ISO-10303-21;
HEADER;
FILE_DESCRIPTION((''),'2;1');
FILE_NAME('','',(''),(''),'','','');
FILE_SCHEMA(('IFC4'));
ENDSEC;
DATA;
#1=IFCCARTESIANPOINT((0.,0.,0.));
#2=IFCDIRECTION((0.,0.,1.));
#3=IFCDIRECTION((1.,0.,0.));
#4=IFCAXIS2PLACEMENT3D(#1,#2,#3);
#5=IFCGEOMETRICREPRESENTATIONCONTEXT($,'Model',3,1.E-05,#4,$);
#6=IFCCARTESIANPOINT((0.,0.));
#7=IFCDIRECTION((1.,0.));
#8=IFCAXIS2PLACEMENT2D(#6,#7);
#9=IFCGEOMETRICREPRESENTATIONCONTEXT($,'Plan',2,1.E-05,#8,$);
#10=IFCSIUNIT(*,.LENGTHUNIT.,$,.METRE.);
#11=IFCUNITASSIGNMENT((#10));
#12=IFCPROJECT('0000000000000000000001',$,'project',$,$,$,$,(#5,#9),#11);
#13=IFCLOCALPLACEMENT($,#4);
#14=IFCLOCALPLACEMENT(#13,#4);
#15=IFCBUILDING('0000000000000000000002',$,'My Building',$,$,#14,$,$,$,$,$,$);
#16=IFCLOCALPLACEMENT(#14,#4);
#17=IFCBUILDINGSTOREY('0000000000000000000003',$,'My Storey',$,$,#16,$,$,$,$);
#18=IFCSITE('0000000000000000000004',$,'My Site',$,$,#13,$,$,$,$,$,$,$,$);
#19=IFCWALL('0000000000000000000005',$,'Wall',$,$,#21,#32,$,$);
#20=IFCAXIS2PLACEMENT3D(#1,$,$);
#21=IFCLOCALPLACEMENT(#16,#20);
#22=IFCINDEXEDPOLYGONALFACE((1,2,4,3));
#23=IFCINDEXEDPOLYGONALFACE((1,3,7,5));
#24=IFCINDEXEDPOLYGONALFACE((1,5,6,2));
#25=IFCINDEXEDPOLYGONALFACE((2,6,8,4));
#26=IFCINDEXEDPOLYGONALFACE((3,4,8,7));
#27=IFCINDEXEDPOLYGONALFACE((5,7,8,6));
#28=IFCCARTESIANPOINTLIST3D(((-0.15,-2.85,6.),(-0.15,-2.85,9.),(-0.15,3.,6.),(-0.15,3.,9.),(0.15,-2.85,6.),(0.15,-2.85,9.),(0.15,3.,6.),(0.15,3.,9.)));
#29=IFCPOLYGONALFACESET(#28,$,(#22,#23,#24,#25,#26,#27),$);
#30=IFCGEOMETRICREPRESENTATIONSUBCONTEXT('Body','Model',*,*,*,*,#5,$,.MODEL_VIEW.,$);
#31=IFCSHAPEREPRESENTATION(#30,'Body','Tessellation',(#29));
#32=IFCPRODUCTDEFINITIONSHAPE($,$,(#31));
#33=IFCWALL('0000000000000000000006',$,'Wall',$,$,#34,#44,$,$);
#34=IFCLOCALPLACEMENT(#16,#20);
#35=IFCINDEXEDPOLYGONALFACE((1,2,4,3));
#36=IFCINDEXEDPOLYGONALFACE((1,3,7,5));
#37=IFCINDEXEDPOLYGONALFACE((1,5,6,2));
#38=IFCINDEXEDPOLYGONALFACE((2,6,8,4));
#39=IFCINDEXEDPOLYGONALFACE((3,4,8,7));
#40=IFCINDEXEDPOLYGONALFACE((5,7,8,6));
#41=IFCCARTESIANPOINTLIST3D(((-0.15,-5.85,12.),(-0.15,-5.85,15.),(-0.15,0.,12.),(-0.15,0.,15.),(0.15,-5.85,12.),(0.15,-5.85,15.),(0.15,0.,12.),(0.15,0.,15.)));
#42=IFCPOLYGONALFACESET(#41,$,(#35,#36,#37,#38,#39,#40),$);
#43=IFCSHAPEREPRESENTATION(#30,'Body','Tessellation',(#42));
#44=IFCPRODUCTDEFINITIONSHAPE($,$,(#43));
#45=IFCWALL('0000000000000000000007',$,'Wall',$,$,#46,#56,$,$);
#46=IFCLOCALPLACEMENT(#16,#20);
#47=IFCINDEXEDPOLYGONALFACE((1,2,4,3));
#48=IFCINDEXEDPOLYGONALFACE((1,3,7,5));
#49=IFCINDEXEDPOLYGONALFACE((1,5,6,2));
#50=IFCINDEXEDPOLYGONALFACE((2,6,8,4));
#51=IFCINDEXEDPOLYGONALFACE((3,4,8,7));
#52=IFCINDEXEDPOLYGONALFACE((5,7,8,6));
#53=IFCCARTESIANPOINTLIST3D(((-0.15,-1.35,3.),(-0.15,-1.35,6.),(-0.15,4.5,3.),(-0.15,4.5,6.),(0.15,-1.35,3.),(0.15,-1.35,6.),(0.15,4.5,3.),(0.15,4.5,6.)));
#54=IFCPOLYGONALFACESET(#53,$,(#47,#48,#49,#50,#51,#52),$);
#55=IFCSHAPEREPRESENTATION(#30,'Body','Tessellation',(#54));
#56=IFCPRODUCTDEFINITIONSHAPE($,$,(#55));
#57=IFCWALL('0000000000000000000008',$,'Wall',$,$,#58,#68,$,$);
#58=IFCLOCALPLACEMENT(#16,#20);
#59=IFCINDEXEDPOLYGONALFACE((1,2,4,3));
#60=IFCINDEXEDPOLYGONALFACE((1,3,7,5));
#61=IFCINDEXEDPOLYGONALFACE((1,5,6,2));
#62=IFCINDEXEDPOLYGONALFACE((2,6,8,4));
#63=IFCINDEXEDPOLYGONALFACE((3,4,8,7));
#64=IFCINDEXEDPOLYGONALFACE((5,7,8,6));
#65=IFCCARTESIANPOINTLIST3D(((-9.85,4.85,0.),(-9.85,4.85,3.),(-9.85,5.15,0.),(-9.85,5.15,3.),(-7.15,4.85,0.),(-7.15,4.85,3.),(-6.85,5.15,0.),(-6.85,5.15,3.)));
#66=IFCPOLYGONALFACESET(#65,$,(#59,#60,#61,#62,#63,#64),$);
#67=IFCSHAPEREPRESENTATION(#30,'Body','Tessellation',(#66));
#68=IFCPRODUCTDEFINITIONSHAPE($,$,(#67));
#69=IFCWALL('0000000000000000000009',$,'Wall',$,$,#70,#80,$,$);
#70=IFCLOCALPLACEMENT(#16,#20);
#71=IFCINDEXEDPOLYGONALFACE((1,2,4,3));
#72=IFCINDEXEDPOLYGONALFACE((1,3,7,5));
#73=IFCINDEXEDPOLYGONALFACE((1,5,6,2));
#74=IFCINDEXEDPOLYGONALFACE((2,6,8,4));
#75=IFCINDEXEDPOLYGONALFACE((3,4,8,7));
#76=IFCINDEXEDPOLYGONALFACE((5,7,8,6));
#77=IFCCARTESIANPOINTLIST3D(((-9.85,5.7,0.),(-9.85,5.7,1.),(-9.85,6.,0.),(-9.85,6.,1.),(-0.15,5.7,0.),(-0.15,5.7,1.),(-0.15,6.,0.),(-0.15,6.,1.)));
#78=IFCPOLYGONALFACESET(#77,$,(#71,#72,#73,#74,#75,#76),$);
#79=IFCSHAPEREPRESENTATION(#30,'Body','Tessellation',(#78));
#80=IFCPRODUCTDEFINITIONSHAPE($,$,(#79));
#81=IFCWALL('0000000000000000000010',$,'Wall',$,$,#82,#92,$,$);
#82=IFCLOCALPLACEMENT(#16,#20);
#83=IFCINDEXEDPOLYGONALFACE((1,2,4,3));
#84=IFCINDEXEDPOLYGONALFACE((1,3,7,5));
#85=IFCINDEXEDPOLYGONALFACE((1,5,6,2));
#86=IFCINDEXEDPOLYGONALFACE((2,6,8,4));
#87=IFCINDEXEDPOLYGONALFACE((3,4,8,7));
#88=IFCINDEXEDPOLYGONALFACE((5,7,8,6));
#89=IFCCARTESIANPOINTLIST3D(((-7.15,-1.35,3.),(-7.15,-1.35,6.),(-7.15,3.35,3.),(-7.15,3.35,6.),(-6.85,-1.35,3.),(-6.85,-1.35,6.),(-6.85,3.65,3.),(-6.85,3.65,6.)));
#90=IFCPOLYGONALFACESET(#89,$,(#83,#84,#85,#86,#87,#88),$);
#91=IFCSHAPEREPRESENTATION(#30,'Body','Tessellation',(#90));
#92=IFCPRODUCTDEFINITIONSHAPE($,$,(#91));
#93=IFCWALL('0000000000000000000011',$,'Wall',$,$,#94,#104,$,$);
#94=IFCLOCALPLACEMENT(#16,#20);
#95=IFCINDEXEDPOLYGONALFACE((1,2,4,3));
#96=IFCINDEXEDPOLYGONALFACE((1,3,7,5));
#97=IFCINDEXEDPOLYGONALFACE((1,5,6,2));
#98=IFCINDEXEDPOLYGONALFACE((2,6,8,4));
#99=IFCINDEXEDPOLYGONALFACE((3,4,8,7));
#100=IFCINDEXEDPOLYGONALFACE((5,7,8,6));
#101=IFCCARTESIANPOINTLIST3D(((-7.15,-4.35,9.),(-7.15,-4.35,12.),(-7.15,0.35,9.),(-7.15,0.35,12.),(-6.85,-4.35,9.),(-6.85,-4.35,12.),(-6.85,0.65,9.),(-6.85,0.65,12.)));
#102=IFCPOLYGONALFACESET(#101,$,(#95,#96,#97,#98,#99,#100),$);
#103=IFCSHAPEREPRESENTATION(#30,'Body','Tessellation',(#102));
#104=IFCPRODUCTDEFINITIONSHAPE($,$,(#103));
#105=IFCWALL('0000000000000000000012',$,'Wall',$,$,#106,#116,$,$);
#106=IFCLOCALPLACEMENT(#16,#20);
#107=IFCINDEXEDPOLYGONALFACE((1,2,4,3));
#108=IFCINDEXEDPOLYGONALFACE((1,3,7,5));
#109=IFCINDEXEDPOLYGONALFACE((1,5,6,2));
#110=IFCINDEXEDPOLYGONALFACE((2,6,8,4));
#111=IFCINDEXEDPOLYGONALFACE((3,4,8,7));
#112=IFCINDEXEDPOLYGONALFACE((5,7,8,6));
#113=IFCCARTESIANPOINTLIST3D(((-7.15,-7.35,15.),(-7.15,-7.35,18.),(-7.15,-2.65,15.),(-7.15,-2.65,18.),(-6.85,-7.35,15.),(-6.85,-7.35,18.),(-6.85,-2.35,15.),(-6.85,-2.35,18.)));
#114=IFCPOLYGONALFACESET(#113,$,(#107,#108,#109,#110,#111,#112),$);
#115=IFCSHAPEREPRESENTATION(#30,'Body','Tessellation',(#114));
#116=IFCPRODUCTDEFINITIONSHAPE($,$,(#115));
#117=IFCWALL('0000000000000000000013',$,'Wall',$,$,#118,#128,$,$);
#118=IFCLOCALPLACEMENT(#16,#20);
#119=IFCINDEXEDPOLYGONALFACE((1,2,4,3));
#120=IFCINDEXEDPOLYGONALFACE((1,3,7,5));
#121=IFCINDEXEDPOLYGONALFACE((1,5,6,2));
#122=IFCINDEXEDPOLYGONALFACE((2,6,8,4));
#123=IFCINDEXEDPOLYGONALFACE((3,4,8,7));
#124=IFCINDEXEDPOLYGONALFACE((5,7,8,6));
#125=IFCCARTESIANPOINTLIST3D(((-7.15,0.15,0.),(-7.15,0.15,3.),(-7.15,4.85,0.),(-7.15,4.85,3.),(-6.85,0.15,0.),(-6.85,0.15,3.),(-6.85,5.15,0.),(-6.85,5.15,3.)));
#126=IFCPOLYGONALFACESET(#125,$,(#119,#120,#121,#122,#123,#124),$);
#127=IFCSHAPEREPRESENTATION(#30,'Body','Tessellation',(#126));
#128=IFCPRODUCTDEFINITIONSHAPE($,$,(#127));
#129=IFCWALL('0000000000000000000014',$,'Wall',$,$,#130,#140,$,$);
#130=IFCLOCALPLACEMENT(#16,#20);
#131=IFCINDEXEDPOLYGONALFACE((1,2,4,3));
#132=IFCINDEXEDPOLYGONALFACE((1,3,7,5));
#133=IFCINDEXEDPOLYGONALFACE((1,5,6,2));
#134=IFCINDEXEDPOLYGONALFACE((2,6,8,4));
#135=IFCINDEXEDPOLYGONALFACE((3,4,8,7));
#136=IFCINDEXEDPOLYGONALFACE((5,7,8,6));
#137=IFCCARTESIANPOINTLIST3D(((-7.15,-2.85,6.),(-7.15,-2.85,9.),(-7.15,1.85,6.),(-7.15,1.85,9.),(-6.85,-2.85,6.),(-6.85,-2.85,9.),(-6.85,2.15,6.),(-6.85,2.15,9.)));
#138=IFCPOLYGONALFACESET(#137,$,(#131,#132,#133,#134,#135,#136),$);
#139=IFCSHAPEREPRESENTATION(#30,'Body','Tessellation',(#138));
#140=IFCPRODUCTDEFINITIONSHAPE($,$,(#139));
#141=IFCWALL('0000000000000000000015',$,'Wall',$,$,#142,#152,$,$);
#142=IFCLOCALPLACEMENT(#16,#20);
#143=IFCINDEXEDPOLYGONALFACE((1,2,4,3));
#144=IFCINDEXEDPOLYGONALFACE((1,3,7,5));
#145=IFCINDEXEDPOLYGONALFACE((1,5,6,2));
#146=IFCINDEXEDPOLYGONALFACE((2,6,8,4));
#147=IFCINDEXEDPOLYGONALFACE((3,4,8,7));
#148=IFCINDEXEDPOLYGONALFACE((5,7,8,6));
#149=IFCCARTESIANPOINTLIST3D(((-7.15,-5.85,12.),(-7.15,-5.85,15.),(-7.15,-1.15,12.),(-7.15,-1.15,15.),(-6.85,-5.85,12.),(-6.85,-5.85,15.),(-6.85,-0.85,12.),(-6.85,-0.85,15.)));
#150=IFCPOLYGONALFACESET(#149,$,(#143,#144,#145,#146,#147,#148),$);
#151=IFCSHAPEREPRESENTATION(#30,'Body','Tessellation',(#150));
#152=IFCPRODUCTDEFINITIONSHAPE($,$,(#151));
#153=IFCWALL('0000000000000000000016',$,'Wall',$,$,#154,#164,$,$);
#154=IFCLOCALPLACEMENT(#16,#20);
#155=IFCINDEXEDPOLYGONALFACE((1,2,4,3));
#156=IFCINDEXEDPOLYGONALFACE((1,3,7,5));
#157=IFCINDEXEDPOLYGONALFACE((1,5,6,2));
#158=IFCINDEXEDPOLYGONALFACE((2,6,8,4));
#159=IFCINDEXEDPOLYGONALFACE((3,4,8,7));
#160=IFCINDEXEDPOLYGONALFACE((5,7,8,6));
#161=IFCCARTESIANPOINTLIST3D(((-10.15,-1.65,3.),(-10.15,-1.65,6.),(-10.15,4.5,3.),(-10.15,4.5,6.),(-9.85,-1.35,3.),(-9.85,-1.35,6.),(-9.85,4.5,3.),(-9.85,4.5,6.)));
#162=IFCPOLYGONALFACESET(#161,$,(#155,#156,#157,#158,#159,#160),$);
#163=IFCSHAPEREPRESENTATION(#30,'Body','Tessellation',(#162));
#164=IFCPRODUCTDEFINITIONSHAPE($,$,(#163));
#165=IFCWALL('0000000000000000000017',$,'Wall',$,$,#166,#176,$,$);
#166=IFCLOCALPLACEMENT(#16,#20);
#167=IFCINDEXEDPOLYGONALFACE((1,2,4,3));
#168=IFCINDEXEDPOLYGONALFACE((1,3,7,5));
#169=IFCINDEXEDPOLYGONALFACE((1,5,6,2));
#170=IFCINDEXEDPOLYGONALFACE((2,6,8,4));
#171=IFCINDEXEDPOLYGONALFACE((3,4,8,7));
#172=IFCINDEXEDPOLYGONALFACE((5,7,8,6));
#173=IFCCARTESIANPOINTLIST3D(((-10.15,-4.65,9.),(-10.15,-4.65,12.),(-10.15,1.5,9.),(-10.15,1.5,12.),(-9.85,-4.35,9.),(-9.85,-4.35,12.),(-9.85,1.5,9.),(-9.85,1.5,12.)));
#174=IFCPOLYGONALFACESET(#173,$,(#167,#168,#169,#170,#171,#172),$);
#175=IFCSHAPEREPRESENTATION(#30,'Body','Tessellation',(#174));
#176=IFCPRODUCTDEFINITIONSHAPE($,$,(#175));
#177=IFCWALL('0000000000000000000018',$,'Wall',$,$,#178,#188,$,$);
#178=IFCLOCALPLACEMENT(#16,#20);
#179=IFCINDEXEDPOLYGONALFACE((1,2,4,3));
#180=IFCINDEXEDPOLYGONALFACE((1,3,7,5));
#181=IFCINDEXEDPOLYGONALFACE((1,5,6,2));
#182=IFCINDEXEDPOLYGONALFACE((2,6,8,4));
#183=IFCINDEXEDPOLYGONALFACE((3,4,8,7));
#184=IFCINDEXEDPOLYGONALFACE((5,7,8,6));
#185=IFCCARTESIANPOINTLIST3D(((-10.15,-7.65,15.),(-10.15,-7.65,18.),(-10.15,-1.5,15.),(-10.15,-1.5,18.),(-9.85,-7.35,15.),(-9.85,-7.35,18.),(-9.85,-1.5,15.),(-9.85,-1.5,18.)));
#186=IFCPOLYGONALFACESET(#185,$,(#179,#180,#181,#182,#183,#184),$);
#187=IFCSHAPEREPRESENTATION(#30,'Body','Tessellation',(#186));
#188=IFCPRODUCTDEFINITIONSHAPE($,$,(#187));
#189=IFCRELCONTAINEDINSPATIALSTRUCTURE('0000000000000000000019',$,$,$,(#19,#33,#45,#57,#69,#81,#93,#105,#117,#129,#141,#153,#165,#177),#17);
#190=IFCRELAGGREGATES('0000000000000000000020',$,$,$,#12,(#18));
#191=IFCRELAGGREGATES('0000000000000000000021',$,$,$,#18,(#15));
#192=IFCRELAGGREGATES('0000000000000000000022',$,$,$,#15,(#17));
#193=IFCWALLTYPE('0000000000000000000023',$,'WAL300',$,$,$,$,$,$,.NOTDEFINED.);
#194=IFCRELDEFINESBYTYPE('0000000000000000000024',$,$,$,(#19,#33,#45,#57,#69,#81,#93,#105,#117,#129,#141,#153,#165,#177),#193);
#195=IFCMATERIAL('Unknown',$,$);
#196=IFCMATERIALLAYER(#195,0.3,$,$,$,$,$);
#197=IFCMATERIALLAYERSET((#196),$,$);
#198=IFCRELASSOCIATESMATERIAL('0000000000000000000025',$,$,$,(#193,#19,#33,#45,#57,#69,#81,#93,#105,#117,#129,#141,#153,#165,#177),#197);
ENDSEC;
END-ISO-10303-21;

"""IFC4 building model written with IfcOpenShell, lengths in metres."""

from ifc_helpers import new_model, si_unit, frame, origin_with_axes, origin_2d_with_axis, place, context, subcontext, project, spatial, line, indexed_curve, outline, extrude, material, layer, layer_set, layer_usage, type_object, element, save


model = new_model("IFC4")

# Units and contexts
model_context = context("Model", 3, precision=1e-05, world=origin_with_axes())
plan_context = context("Plan", 2, precision=1e-05, world=origin_2d_with_axis())
body_context = subcontext(model_context, "Body", "Model", "MODEL_VIEW")
ifc_project = project(units=[si_unit("LENGTHUNIT", "METRE")], contexts=[model_context, plan_context])

# Site, building, storey
site_placement = place(None, origin_with_axes())
site = spatial("IfcSite", under=ifc_project, at=site_placement, Name="My Site")
building_placement = place(site_placement, origin_with_axes())
building = spatial("IfcBuilding", under=site, at=building_placement, Name="My Building")
storey_placement = place(building_placement, origin_with_axes())
storey = spatial("IfcBuildingStorey", under=building, at=storey_placement, Name="My Storey")

# Walls
ifc_material = material(Name="Unknown")
ifc_layer = layer(ifc_material, 0.3)
ifc_layer_set = layer_set([ifc_layer])
ifc_layer_usage_1 = layer_usage(ifc_layer_set, "AXIS2", "POSITIVE", -0.15)
wall_type = type_object("IfcWallType", Name="WAL300", PredefinedType="NOTDEFINED", material=ifc_layer_set)
wall_1_placement = place(storey_placement, frame((0.0, -3.0, 6.0), z_axis=(0.0, 0.0, 1.0), x_axis=(0.0, 1.0, 0.0)))
element("IfcWall", 1, at=wall_1_placement, inside=storey, type_object=wall_type, material=ifc_layer_usage_1, Name="Wall", context=body_context, shape_type="SweptSolid", body=[
    extrude(outline(indexed_curve([(0.15, -0.15), (0.15, 0.15), (6.0, 0.15), (6.0, -0.15)], segments=[line(1, 2, 3, 4, 1)])), origin_with_axes(), (0.0, 0.0, 1.0), 3.0),
])
ifc_layer_usage_2 = layer_usage(ifc_layer_set, "AXIS2", "POSITIVE", -0.15)
wall_2_placement = place(storey_placement, frame((0.0, -6.0, 12.0), z_axis=(0.0, 0.0, 1.0), x_axis=(0.0, 1.0, 0.0)))
element("IfcWall", 2, at=wall_2_placement, inside=storey, type_object=wall_type, material=ifc_layer_usage_2, Name="Wall", context=body_context, shape_type="SweptSolid", body=[
    extrude(outline(indexed_curve([(0.15, -0.15), (0.15, 0.15), (6.0, 0.15), (6.0, -0.15)], segments=[line(1, 2, 3, 4, 1)])), origin_with_axes(), (0.0, 0.0, 1.0), 3.0),
])
ifc_layer_usage_3 = layer_usage(ifc_layer_set, "AXIS2", "POSITIVE", -0.15)
wall_3_placement = place(storey_placement, frame((0.0, -1.5, 3.0), z_axis=(0.0, 0.0, 1.0), x_axis=(0.0, 1.0, 0.0)))
element("IfcWall", 3, at=wall_3_placement, inside=storey, type_object=wall_type, material=ifc_layer_usage_3, Name="Wall", context=body_context, shape_type="SweptSolid", body=[
    extrude(outline(indexed_curve([(0.15, -0.15), (0.15, 0.15), (6.0, 0.15), (6.0, -0.15)], segments=[line(1, 2, 3, 4, 1)])), origin_with_axes(), (0.0, 0.0, 1.0), 3.0),
])
ifc_layer_usage_4 = layer_usage(ifc_layer_set, "AXIS2", "POSITIVE", -0.15)
wall_4_placement = place(storey_placement, frame((-10.0, 5.0, 0.0), z_axis=(0.0, 0.0, 1.0), x_axis=(1.0, 0.0, 0.0)))
element("IfcWall", 4, at=wall_4_placement, inside=storey, type_object=wall_type, material=ifc_layer_usage_4, Name="Wall", context=body_context, shape_type="SweptSolid", body=[
    extrude(outline(indexed_curve([(0.15, -0.15), (0.15, 0.15), (3.15, 0.15), (2.85, -0.15)], segments=[line(1, 2, 3, 4, 1)])), origin_with_axes(), (0.0, 0.0, 1.0), 3.0),
])
ifc_layer_usage_5 = layer_usage(ifc_layer_set, "AXIS2", "POSITIVE", -0.3)
wall_5_placement = place(storey_placement, frame((-9.85, 6.0, 0.0), z_axis=(0.0, 0.0, 1.0), x_axis=(1.0, 0.0, 0.0)))
element("IfcWall", 5, at=wall_5_placement, inside=storey, type_object=wall_type, material=ifc_layer_usage_5, Name="Wall", context=body_context, shape_type="SweptSolid", body=[
    extrude(outline(indexed_curve([(0.0, -0.3), (0.0, 0.0), (9.7, 0.0), (9.7, -0.3)], segments=[line(1, 2, 3, 4, 1)])), origin_with_axes(), (0.0, 0.0, 1.0), 1.0),
])
ifc_layer_usage_6 = layer_usage(ifc_layer_set, "AXIS2", "POSITIVE", -0.15)
wall_6_placement = place(storey_placement, frame((-7.0, -1.5, 3.0), z_axis=(0.0, 0.0, 1.0), x_axis=(0.0, 1.0, 0.0)))
element("IfcWall", 6, at=wall_6_placement, inside=storey, type_object=wall_type, material=ifc_layer_usage_6, Name="Wall", context=body_context, shape_type="SweptSolid", body=[
    extrude(outline(indexed_curve([(0.15, -0.15), (0.15, 0.15), (4.85, 0.15), (5.15, -0.15)], segments=[line(1, 2, 3, 4, 1)])), origin_with_axes(), (0.0, 0.0, 1.0), 3.0),
])
ifc_layer_usage_7 = layer_usage(ifc_layer_set, "AXIS2", "POSITIVE", -0.15)
wall_7_placement = place(storey_placement, frame((-7.0, -4.5, 9.0), z_axis=(0.0, 0.0, 1.0), x_axis=(0.0, 1.0, 0.0)))
element("IfcWall", 7, at=wall_7_placement, inside=storey, type_object=wall_type, material=ifc_layer_usage_7, Name="Wall", context=body_context, shape_type="SweptSolid", body=[
    extrude(outline(indexed_curve([(0.15, -0.15), (0.15, 0.15), (4.85, 0.15), (5.15, -0.15)], segments=[line(1, 2, 3, 4, 1)])), origin_with_axes(), (0.0, 0.0, 1.0), 3.0),
])
ifc_layer_usage_8 = layer_usage(ifc_layer_set, "AXIS2", "POSITIVE", -0.15)
wall_8_placement = place(storey_placement, frame((-7.0, -7.5, 15.0), z_axis=(0.0, 0.0, 1.0), x_axis=(0.0, 1.0, 0.0)))
element("IfcWall", 8, at=wall_8_placement, inside=storey, type_object=wall_type, material=ifc_layer_usage_8, Name="Wall", context=body_context, shape_type="SweptSolid", body=[
    extrude(outline(indexed_curve([(0.15, -0.15), (0.15, 0.15), (4.85, 0.15), (5.15, -0.15)], segments=[line(1, 2, 3, 4, 1)])), origin_with_axes(), (0.0, 0.0, 1.0), 3.0),
])
ifc_layer_usage_9 = layer_usage(ifc_layer_set, "AXIS2", "POSITIVE", -0.15)
wall_9_placement = place(storey_placement, frame((-7.0, 0.0, 0.0), z_axis=(0.0, 0.0, 1.0), x_axis=(0.0, 1.0, 0.0)))
element("IfcWall", 9, at=wall_9_placement, inside=storey, type_object=wall_type, material=ifc_layer_usage_9, Name="Wall", context=body_context, shape_type="SweptSolid", body=[
    extrude(outline(indexed_curve([(0.15, -0.15), (0.15, 0.15), (4.85, 0.15), (5.15, -0.15)], segments=[line(1, 2, 3, 4, 1)])), origin_with_axes(), (0.0, 0.0, 1.0), 3.0),
])
ifc_layer_usage_10 = layer_usage(ifc_layer_set, "AXIS2", "POSITIVE", -0.15)
wall_10_placement = place(storey_placement, frame((-7.0, -3.0, 6.0), z_axis=(0.0, 0.0, 1.0), x_axis=(0.0, 1.0, 0.0)))
element("IfcWall", 10, at=wall_10_placement, inside=storey, type_object=wall_type, material=ifc_layer_usage_10, Name="Wall", context=body_context, shape_type="SweptSolid", body=[
    extrude(outline(indexed_curve([(0.15, -0.15), (0.15, 0.15), (4.85, 0.15), (5.15, -0.15)], segments=[line(1, 2, 3, 4, 1)])), origin_with_axes(), (0.0, 0.0, 1.0), 3.0),
])
ifc_layer_usage_11 = layer_usage(ifc_layer_set, "AXIS2", "POSITIVE", -0.15)
wall_11_placement = place(storey_placement, frame((-7.0, -6.0, 12.0), z_axis=(0.0, 0.0, 1.0), x_axis=(0.0, 1.0, 0.0)))
element("IfcWall", 11, at=wall_11_placement, inside=storey, type_object=wall_type, material=ifc_layer_usage_11, Name="Wall", context=body_context, shape_type="SweptSolid", body=[
    extrude(outline(indexed_curve([(0.15, -0.15), (0.15, 0.15), (4.85, 0.15), (5.15, -0.15)], segments=[line(1, 2, 3, 4, 1)])), origin_with_axes(), (0.0, 0.0, 1.0), 3.0),
])
ifc_layer_usage_12 = layer_usage(ifc_layer_set, "AXIS2", "POSITIVE", -0.15)
wall_12_placement = place(storey_placement, frame((-10.0, -1.5, 3.0), z_axis=(0.0, 0.0, 1.0), x_axis=(0.0, 1.0, 0.0)))
element("IfcWall", 12, at=wall_12_placement, inside=storey, type_object=wall_type, material=ifc_layer_usage_12, Name="Wall", context=body_context, shape_type="SweptSolid", body=[
    extrude(outline(indexed_curve([(0.15, -0.15), (-0.15, 0.15), (6.0, 0.15), (6.0, -0.15)], segments=[line(1, 2, 3, 4, 1)])), origin_with_axes(), (0.0, 0.0, 1.0), 3.0),
])
ifc_layer_usage_13 = layer_usage(ifc_layer_set, "AXIS2", "POSITIVE", -0.15)
wall_13_placement = place(storey_placement, frame((-10.0, -4.5, 9.0), z_axis=(0.0, 0.0, 1.0), x_axis=(0.0, 1.0, 0.0)))
element("IfcWall", 13, at=wall_13_placement, inside=storey, type_object=wall_type, material=ifc_layer_usage_13, Name="Wall", context=body_context, shape_type="SweptSolid", body=[
    extrude(outline(indexed_curve([(0.15, -0.15), (-0.15, 0.15), (6.0, 0.15), (6.0, -0.15)], segments=[line(1, 2, 3, 4, 1)])), origin_with_axes(), (0.0, 0.0, 1.0), 3.0),
])
ifc_layer_usage_14 = layer_usage(ifc_layer_set, "AXIS2", "POSITIVE", -0.15)
wall_14_placement = place(storey_placement, frame((-10.0, -7.5, 15.0), z_axis=(0.0, 0.0, 1.0), x_axis=(0.0, 1.0, 0.0)))
element("IfcWall", 14, at=wall_14_placement, inside=storey, type_object=wall_type, material=ifc_layer_usage_14, Name="Wall", context=body_context, shape_type="SweptSolid", body=[
    extrude(outline(indexed_curve([(0.15, -0.15), (-0.15, 0.15), (6.0, 0.15), (6.0, -0.15)], segments=[line(1, 2, 3, 4, 1)])), origin_with_axes(), (0.0, 0.0, 1.0), 3.0),
])

save(model, "model.ifc")
